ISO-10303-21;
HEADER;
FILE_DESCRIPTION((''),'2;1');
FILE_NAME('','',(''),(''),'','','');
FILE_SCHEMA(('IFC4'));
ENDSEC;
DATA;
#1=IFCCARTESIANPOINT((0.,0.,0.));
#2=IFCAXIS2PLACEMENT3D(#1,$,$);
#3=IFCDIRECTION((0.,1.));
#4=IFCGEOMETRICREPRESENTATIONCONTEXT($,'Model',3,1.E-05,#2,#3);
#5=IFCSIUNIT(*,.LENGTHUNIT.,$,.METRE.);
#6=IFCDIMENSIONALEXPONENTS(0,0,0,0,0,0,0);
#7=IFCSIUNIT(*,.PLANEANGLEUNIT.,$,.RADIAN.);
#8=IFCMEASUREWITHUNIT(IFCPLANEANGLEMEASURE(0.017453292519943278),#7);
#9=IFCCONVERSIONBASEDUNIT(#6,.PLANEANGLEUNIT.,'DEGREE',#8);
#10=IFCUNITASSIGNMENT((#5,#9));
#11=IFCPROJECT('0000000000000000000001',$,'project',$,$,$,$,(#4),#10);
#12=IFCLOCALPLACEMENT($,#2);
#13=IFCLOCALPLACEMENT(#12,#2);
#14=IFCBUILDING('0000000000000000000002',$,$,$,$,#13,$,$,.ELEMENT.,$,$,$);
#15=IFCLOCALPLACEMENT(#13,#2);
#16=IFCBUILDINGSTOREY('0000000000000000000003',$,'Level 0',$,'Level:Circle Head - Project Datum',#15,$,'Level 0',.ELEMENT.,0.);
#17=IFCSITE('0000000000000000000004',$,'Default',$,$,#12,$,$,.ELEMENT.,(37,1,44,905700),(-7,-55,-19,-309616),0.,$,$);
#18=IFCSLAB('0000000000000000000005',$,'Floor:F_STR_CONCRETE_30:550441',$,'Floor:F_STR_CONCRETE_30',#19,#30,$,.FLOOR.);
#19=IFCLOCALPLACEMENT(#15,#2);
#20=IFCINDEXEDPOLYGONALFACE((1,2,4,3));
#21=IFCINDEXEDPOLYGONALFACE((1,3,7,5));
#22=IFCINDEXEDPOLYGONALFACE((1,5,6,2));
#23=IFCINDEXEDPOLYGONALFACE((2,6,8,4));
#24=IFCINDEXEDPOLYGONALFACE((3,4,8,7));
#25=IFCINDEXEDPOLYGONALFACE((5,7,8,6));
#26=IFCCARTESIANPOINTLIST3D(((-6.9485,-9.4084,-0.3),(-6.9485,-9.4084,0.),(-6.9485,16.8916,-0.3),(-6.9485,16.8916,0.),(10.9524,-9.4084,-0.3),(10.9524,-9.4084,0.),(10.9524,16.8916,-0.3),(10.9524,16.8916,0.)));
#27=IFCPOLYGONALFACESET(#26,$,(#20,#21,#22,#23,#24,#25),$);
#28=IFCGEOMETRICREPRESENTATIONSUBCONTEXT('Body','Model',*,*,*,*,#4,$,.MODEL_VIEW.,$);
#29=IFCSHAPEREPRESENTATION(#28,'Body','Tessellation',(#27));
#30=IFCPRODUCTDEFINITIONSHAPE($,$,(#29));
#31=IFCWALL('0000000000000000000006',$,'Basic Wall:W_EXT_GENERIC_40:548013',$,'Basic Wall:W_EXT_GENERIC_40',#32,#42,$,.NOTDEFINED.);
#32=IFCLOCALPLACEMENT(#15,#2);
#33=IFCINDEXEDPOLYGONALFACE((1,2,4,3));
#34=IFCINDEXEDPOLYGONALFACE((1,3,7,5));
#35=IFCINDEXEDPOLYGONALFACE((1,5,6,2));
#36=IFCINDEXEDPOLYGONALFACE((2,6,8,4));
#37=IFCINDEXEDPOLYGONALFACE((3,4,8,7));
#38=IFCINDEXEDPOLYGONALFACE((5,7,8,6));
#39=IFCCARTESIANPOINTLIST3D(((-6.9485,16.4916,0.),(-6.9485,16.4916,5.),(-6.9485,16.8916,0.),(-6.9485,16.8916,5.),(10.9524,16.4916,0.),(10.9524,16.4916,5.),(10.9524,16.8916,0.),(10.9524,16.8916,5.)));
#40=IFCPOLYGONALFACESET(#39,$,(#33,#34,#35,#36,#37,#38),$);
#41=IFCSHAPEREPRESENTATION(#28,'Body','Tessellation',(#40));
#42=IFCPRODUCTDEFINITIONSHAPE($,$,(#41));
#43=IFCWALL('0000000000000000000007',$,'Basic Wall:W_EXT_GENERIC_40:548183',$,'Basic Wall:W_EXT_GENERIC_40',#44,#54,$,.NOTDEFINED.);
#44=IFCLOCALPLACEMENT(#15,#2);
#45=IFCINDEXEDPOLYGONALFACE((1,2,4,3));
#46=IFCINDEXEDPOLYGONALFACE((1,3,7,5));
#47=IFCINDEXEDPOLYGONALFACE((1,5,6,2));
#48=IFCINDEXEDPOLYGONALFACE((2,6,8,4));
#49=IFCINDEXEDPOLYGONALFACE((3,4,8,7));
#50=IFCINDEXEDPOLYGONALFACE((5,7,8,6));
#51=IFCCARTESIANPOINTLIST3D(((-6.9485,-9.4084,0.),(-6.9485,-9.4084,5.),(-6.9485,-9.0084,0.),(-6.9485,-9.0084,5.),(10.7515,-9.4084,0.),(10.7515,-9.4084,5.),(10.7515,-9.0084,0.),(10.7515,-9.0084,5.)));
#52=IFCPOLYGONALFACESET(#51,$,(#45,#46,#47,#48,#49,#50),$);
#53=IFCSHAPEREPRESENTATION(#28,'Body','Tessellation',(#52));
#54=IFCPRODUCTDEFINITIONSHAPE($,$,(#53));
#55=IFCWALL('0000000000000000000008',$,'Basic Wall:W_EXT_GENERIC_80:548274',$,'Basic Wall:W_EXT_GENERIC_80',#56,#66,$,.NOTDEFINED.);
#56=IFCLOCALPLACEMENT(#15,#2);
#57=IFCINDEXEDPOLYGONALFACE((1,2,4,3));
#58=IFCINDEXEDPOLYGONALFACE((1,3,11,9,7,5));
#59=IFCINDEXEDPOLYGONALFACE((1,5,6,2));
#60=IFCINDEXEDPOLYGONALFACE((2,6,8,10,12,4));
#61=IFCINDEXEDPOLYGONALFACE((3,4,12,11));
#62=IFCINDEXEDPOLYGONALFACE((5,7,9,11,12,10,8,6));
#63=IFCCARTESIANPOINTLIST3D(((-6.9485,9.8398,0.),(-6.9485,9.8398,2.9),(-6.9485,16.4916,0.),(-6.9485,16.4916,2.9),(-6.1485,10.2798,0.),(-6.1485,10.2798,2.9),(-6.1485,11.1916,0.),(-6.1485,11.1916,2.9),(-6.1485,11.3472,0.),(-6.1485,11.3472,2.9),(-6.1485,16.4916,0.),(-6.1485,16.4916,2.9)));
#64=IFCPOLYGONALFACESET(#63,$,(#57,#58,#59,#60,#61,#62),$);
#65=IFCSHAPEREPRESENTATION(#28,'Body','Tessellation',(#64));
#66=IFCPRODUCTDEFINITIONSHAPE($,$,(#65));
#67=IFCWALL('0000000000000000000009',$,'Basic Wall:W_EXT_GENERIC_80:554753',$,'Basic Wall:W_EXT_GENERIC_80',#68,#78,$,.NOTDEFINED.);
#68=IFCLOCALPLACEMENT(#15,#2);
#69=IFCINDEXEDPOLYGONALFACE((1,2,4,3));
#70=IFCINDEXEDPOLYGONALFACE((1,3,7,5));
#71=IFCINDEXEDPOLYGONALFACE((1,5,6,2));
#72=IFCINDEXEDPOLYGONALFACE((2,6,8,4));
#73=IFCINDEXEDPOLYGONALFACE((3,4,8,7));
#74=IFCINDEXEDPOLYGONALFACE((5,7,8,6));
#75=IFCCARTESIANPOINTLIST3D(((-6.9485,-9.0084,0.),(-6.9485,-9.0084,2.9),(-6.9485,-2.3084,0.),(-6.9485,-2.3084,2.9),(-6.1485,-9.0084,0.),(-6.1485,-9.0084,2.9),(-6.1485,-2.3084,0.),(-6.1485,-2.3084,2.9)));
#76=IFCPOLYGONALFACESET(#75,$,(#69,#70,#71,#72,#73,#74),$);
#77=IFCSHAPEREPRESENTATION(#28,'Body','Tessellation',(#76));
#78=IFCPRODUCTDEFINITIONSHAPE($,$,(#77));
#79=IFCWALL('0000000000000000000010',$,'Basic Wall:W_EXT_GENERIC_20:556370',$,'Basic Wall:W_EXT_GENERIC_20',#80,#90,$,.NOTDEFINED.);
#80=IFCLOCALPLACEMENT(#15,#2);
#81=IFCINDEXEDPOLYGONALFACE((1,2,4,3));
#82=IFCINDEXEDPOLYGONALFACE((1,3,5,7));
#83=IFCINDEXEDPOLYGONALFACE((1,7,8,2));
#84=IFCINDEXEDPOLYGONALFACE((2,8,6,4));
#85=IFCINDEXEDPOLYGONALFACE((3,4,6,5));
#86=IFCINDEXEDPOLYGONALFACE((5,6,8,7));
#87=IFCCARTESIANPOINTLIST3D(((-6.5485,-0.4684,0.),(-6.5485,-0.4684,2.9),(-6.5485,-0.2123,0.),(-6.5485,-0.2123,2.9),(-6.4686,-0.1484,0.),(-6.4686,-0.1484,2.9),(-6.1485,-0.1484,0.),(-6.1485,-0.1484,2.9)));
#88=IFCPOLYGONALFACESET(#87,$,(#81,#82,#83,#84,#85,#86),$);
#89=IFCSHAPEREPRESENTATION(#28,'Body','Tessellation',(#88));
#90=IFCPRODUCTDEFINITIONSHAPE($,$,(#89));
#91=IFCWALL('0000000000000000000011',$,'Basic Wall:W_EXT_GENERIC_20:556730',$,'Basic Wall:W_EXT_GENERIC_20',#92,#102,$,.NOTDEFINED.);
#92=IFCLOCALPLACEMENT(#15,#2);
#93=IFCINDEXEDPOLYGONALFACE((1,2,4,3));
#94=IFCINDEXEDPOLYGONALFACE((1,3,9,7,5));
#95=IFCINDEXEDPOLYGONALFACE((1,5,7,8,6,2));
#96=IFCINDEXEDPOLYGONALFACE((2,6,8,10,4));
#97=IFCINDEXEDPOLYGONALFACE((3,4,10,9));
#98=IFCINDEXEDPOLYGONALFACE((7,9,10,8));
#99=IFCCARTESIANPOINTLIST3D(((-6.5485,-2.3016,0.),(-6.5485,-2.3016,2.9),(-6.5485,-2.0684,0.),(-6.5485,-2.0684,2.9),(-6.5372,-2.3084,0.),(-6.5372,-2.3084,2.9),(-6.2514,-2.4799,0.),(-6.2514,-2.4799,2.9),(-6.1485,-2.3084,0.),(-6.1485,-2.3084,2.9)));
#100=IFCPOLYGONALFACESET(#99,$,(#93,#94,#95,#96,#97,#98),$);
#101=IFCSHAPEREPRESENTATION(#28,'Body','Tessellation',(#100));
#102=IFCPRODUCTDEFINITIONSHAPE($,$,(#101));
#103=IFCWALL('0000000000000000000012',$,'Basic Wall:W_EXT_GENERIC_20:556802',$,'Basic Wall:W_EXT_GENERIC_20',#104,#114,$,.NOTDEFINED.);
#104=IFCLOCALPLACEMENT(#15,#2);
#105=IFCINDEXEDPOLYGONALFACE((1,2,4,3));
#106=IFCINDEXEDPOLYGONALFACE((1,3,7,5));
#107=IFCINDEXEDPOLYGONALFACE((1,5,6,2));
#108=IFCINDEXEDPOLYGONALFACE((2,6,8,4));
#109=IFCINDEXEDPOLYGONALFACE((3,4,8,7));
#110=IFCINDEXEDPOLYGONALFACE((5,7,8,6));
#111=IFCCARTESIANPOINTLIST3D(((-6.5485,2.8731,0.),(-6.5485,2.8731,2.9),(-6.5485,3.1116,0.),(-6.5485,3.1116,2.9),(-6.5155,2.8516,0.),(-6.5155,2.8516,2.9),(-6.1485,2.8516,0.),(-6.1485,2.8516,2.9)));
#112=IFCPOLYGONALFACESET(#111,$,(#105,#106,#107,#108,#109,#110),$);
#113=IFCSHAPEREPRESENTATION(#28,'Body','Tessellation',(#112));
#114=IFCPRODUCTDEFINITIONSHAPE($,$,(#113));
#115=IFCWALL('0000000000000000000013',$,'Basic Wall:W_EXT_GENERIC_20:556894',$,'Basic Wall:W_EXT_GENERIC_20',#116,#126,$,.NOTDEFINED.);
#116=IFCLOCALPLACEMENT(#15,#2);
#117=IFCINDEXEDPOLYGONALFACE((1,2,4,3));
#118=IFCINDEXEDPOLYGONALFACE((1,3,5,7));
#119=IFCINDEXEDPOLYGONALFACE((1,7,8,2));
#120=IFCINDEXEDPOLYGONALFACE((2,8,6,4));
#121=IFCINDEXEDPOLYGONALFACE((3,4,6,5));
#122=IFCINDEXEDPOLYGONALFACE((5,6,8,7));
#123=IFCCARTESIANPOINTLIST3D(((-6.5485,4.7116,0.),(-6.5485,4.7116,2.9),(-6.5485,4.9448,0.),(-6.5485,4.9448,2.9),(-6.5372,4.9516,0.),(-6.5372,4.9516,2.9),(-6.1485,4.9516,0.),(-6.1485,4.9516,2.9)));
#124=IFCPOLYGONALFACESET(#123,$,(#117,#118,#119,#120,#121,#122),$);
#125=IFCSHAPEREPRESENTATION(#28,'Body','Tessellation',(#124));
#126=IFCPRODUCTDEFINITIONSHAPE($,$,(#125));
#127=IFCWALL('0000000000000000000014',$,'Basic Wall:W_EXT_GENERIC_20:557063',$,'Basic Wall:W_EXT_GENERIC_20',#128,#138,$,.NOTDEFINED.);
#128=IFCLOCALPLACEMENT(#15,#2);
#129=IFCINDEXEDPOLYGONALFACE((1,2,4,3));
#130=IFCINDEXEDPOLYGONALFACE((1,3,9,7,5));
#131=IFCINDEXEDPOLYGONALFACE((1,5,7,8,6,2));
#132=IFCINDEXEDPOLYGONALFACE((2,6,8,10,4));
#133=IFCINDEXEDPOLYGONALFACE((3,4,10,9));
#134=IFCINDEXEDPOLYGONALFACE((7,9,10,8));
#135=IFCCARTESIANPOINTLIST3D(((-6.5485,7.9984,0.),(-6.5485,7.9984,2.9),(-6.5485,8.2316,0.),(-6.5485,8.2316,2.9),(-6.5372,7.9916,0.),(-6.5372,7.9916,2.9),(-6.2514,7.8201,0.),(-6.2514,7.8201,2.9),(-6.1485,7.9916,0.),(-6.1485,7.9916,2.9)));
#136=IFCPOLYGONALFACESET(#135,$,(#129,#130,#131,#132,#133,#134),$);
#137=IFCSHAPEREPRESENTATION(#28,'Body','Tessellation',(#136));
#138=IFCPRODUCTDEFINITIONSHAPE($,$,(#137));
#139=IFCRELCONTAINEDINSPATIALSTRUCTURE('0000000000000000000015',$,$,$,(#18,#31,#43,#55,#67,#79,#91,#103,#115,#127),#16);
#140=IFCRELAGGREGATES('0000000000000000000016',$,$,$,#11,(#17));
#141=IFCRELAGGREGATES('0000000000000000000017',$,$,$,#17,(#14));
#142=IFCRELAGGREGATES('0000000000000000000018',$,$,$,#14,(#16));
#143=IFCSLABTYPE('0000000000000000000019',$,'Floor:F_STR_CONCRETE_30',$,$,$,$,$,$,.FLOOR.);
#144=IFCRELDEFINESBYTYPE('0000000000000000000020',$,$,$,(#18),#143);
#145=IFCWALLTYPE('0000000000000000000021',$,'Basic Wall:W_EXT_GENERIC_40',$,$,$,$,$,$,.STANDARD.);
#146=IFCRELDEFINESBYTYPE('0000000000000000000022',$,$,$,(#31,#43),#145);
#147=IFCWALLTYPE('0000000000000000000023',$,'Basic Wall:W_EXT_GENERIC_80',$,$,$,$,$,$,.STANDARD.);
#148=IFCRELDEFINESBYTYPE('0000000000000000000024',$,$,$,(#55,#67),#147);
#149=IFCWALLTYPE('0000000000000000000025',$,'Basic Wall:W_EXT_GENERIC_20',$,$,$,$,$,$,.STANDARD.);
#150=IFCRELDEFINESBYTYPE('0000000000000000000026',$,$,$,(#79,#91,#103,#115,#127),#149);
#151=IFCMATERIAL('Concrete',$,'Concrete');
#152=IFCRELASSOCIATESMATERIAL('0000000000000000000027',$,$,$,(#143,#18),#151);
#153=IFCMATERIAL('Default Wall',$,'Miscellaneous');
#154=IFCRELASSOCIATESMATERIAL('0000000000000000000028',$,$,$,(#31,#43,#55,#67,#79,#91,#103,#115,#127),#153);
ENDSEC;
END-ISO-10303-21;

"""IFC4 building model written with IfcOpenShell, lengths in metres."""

from ifc_helpers import new_model, entity, si_unit, converted_unit, direction, frame, origin, place, context, subcontext, project, spatial, indexed_curve, outline, extrude, material, type_object, element, save


model = new_model("IFC4")

# Units and contexts
model_context = context("Model", 3, precision=1e-05, world=origin(), true_north=direction((0.0, 1.0)))
body_context = subcontext(model_context, "Body", "Model", "MODEL_VIEW")
ifc_project = project(units=[si_unit("LENGTHUNIT", "METRE"), converted_unit("PLANEANGLEUNIT", "DEGREE", entity("IfcPlaneAngleMeasure", 0.017453292519943278), si_unit("PLANEANGLEUNIT", "RADIAN"), dimensions=[0, 0, 0, 0, 0, 0, 0])], contexts=[model_context])

# Site, building, storey
site_placement = place(None, origin())
site = spatial("IfcSite", under=ifc_project, at=site_placement, Name="Default", CompositionType="ELEMENT", RefLatitude=(37, 1, 44, 905700), RefLongitude=(-7, -55, -19, -309616), RefElevation=0.0)
building_placement = place(site_placement, origin())
building = spatial("IfcBuilding", under=site, at=building_placement, CompositionType="ELEMENT")
storey_placement = place(building_placement, origin())
storey = spatial("IfcBuildingStorey", under=building, at=storey_placement, Name="Level 0", ObjectType="Level:Circle Head - Project Datum", LongName="Level 0", CompositionType="ELEMENT", Elevation=0.0)

# Slab
ifc_material_1 = material(Name="Concrete", Category="Concrete")
slab_type = type_object("IfcSlabType", Name="Floor:F_STR_CONCRETE_30", PredefinedType="FLOOR", material=ifc_material_1)
slab_placement = place(storey_placement, origin())
element("IfcSlab", 1, at=slab_placement, inside=storey, type_object=slab_type, material=ifc_material_1, Name="Floor:F_STR_CONCRETE_30:550441", ObjectType="Floor:F_STR_CONCRETE_30", PredefinedType="FLOOR", context=body_context, shape_type="SweptSolid", body=[
    extrude(outline(indexed_curve([(-13.15, -8.9504), (13.15, -8.9504), (13.15, 8.9504), (-13.15, 8.9504), (-13.15, -8.9504)], self_intersect=False)), frame((2.0019, 3.7416, 0.0), z_axis=(0.0, 0.0, -1.0), x_axis=(0.0, 1.0, 0.0)), (0.0, 0.0, 1.0), 0.3),
])

# Walls
ifc_material_2 = material(Name="Default Wall", Category="Miscellaneous")
wall_type_1 = type_object("IfcWallType", Name="Basic Wall:W_EXT_GENERIC_40", PredefinedType="STANDARD")
wall_1_placement = place(storey_placement, frame((-6.9485, 16.6916, 0.0)))
element("IfcWall", 2, at=wall_1_placement, inside=storey, type_object=wall_type_1, material=ifc_material_2, Name="Basic Wall:W_EXT_GENERIC_40:548013", ObjectType="Basic Wall:W_EXT_GENERIC_40", PredefinedType="NOTDEFINED", context=body_context, shape_type="SweptSolid", body=[
    extrude(outline(indexed_curve([(17.9008, 0.2), (0.0, 0.2), (0.0, -0.2), (17.9008, -0.2), (17.9008, 0.2)], self_intersect=False)), origin(), (0.0, 0.0, 1.0), 5.0),
])
wall_2_placement = place(storey_placement, frame((10.7515, -9.2084, 0.0), z_axis=(0.0, 0.0, 1.0), x_axis=(-1.0, 0.0, 0.0)))
element("IfcWall", 3, at=wall_2_placement, inside=storey, type_object=wall_type_1, material=ifc_material_2, Name="Basic Wall:W_EXT_GENERIC_40:548183", ObjectType="Basic Wall:W_EXT_GENERIC_40", PredefinedType="NOTDEFINED", context=body_context, shape_type="SweptSolid", body=[
    extrude(outline(indexed_curve([(17.7, 0.2), (0.0, 0.2), (0.0, -0.2), (17.7, -0.2), (17.7, 0.2)], self_intersect=False)), origin(), (0.0, 0.0, 1.0), 5.0),
])
wall_type_2 = type_object("IfcWallType", Name="Basic Wall:W_EXT_GENERIC_80", PredefinedType="STANDARD")
wall_3_placement = place(storey_placement, frame((-6.5485, 16.4916, 0.0), z_axis=(0.0, 0.0, 1.0), x_axis=(0.0, -1.0, 0.0)))
element("IfcWall", 4, at=wall_3_placement, inside=storey, type_object=wall_type_2, material=ifc_material_2, Name="Basic Wall:W_EXT_GENERIC_80:548274", ObjectType="Basic Wall:W_EXT_GENERIC_80", PredefinedType="NOTDEFINED", context=body_context, shape_type="SweptSolid", body=[
    extrude(outline(indexed_curve([(6.6517, -0.4), (6.2117, 0.4), (5.3, 0.4), (5.1444, 0.4), (0.0, 0.4), (0.0, -0.4), (6.6517, -0.4)], self_intersect=False)), origin(), (0.0, 0.0, 1.0), 2.9),
])
wall_4_placement = place(storey_placement, frame((-6.5485, -2.3084, 0.0), z_axis=(0.0, 0.0, 1.0), x_axis=(0.0, -1.0, 0.0)))
element("IfcWall", 5, at=wall_4_placement, inside=storey, type_object=wall_type_2, material=ifc_material_2, Name="Basic Wall:W_EXT_GENERIC_80:554753", ObjectType="Basic Wall:W_EXT_GENERIC_80", PredefinedType="NOTDEFINED", context=body_context, shape_type="SweptSolid", body=[
    extrude(outline(indexed_curve([(6.7, 0.4), (0.0, 0.4), (0.0, -0.4), (6.7, -0.4), (6.7, 0.4)], self_intersect=False)), origin(), (0.0, 0.0, 1.0), 2.9),
])
wall_type_3 = type_object("IfcWallType", Name="Basic Wall:W_EXT_GENERIC_20", PredefinedType="STANDARD")
wall_5_placement = place(storey_placement, frame((-6.2109, -0.0703, 0.0), z_axis=(0.0, 0.0, 1.0), x_axis=(-0.780869, -0.624695, 0.0)))
element("IfcWall", 6, at=wall_5_placement, inside=storey, type_object=wall_type_3, material=ifc_material_2, Name="Basic Wall:W_EXT_GENERIC_20:556370", ObjectType="Basic Wall:W_EXT_GENERIC_20", PredefinedType="NOTDEFINED", context=body_context, shape_type="SweptSolid", body=[
    extrude(outline(indexed_curve([(0.0, 0.1), (0.25, -0.1), (0.3522, -0.1), (0.5122, 0.1), (0.0, 0.1)], self_intersect=False)), origin(), (0.0, 0.0, 1.0), 2.9),
])
wall_6_placement = place(storey_placement, frame((-6.1999, -2.3942, 0.0), z_axis=(0.0, 0.0, 1.0), x_axis=(-0.857493, 0.514496, 0.0)))
element("IfcWall", 7, at=wall_6_placement, inside=storey, type_object=wall_type_3, material=ifc_material_2, Name="Basic Wall:W_EXT_GENERIC_20:556730", ObjectType="Basic Wall:W_EXT_GENERIC_20", PredefinedType="NOTDEFINED", context=body_context, shape_type="SweptSolid", body=[
    extrude(outline(indexed_curve([(0.4665, -0.1), (0.3465, 0.1), (0.3333, 0.1), (0.0, 0.1), (0.0, -0.1), (0.4665, -0.1)], self_intersect=False)), origin(), (0.0, 0.0, 1.0), 2.9),
])
wall_7_placement = place(storey_placement, frame((-6.203, 2.7677, 0.0), z_axis=(0.0, 0.0, 1.0), x_axis=(-0.838444, 0.544988, 0.0)))
element("IfcWall", 8, at=wall_7_placement, inside=storey, type_object=wall_type_3, material=ifc_material_2, Name="Basic Wall:W_EXT_GENERIC_20:556802", ObjectType="Basic Wall:W_EXT_GENERIC_20", PredefinedType="NOTDEFINED", context=body_context, shape_type="SweptSolid", body=[
    extrude(outline(indexed_curve([(0.4771, -0.1), (0.3471, 0.1), (0.3077, 0.1), (0.0, -0.1), (0.4771, -0.1)], self_intersect=False)), origin(), (0.0, 0.0, 1.0), 2.9),
])
wall_8_placement = place(storey_placement, frame((-6.1999, 5.0373, 0.0), z_axis=(0.0, 0.0, 1.0), x_axis=(-0.857493, -0.514496, 0.0)))
element("IfcWall", 9, at=wall_8_placement, inside=storey, type_object=wall_type_3, material=ifc_material_2, Name="Basic Wall:W_EXT_GENERIC_20:556894", ObjectType="Basic Wall:W_EXT_GENERIC_20", PredefinedType="NOTDEFINED", context=body_context, shape_type="SweptSolid", body=[
    extrude(outline(indexed_curve([(0.0, 0.1), (0.3333, -0.1), (0.3465, -0.1), (0.4665, 0.1), (0.0, 0.1)], self_intersect=False)), origin(), (0.0, 0.0, 1.0), 2.9),
])
wall_9_placement = place(storey_placement, frame((-6.1999, 7.9058, 0.0), z_axis=(0.0, 0.0, 1.0), x_axis=(-0.857493, 0.514496, 0.0)))
element("IfcWall", 10, at=wall_9_placement, inside=storey, type_object=wall_type_3, material=ifc_material_2, Name="Basic Wall:W_EXT_GENERIC_20:557063", ObjectType="Basic Wall:W_EXT_GENERIC_20", PredefinedType="NOTDEFINED", context=body_context, shape_type="SweptSolid", body=[
    extrude(outline(indexed_curve([(0.4665, -0.1), (0.3465, 0.1), (0.3333, 0.1), (0.0, 0.1), (0.0, -0.1), (0.4665, -0.1)], self_intersect=False)), origin(), (0.0, 0.0, 1.0), 2.9),
])

save(model, "model.ifc")
